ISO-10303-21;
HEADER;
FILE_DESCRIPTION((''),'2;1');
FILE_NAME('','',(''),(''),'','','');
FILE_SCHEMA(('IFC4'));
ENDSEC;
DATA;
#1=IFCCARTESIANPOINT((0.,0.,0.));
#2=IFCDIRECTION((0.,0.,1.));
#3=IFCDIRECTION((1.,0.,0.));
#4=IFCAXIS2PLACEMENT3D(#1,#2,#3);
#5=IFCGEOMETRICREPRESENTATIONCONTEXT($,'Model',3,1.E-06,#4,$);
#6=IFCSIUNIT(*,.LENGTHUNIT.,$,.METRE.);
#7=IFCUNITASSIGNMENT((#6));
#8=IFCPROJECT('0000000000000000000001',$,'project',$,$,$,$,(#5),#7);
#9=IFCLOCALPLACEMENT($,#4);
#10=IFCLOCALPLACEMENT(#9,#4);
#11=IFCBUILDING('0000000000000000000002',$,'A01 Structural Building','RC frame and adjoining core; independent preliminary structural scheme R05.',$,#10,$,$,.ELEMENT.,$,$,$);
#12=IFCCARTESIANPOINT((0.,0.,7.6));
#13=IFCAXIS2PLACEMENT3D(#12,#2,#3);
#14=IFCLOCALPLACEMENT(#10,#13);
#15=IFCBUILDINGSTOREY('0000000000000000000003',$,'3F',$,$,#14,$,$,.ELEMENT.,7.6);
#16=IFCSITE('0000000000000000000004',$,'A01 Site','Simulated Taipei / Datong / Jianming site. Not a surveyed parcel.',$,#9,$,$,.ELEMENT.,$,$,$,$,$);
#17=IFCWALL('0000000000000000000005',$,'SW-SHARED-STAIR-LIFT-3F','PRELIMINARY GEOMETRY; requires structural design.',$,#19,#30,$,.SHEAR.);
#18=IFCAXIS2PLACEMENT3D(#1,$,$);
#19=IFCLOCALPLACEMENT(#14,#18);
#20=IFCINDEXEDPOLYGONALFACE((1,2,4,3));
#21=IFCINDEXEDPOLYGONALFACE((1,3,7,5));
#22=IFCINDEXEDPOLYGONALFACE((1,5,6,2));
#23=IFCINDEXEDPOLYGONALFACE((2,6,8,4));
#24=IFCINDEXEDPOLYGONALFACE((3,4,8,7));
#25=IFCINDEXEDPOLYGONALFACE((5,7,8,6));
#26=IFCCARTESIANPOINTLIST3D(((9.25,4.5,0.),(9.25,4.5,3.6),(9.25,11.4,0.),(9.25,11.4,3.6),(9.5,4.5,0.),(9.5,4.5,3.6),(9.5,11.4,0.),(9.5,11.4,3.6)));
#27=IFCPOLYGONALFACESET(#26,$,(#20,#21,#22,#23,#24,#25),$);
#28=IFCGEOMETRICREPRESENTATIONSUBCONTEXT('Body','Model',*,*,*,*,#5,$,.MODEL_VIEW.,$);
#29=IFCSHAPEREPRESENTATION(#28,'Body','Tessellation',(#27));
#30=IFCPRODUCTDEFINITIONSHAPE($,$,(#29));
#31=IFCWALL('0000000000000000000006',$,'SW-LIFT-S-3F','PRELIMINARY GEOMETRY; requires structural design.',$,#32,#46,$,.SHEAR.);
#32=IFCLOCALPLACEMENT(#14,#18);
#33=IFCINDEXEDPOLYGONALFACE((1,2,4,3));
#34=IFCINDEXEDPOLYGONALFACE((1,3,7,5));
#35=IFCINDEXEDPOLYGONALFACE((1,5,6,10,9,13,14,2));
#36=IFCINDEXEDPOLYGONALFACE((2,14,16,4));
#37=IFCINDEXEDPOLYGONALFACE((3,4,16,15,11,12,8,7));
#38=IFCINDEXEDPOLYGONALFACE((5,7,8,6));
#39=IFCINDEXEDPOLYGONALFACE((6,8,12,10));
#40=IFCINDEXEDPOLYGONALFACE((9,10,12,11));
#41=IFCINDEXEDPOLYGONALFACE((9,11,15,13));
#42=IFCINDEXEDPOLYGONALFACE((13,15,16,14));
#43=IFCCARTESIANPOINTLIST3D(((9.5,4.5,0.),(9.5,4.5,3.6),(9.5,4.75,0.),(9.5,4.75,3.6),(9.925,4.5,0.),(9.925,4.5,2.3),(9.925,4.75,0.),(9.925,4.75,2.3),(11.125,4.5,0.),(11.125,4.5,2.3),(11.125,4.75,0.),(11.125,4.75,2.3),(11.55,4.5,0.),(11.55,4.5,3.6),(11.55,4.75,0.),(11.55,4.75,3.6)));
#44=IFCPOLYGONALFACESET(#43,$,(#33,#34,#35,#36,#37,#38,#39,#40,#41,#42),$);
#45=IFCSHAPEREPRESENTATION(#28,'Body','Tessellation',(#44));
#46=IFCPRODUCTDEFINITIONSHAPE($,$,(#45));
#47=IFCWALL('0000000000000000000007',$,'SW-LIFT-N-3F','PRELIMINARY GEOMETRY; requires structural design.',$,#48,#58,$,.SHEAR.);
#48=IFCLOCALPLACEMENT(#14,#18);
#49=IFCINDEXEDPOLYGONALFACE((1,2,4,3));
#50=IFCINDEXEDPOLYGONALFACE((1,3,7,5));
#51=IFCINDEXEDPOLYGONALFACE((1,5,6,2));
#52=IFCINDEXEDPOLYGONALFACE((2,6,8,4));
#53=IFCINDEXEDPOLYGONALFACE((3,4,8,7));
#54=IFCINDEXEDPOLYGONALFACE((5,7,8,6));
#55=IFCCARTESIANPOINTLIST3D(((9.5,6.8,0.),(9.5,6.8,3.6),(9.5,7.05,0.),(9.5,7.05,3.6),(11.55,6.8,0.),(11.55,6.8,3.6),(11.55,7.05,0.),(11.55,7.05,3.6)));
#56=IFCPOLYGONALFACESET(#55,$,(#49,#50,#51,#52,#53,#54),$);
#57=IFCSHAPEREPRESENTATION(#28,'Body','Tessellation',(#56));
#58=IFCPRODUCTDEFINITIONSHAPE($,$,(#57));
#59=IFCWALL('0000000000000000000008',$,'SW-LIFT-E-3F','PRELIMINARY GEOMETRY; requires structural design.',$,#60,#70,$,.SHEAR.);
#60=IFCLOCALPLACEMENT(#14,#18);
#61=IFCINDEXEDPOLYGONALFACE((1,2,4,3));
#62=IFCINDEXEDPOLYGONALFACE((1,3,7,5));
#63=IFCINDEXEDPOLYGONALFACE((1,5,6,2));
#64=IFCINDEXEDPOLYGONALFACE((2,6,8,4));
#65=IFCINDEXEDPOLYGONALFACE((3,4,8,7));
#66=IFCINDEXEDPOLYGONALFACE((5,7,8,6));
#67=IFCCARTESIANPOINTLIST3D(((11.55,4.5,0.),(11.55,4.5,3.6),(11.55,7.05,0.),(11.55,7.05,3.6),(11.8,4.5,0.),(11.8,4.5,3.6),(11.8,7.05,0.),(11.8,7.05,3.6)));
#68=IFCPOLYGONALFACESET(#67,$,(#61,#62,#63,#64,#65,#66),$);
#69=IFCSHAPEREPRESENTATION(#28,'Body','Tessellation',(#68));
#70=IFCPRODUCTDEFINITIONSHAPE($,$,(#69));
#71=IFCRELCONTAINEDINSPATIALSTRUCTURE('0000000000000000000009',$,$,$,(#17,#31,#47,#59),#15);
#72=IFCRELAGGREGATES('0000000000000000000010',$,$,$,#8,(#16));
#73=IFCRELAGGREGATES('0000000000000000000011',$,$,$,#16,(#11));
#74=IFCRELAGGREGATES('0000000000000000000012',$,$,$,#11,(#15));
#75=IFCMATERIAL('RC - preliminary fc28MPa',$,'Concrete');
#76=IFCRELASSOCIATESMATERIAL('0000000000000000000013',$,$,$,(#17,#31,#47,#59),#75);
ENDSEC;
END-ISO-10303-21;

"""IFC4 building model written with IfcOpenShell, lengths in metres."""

from ifc_helpers import new_model, si_unit, frame, origin_with_axes, place, context, subcontext, project, spatial, rectangle, extrude, material, element, save


model = new_model("IFC4")

# Units and contexts
model_context = context("Model", 3, precision=1e-06, world=origin_with_axes())
body_context = subcontext(model_context, "Body", "Model", "MODEL_VIEW")
ifc_project = project(units=[si_unit("LENGTHUNIT", "METRE")], contexts=[model_context])

# Site, building, storey
site_placement = place(None, origin_with_axes())
site = spatial("IfcSite", under=ifc_project, at=site_placement, Name="A01 Site", Description="Simulated Taipei / Datong / Jianming site. Not a surveyed parcel.", CompositionType="ELEMENT")
building_placement = place(site_placement, origin_with_axes())
building = spatial("IfcBuilding", under=site, at=building_placement, Name="A01 Structural Building", Description="RC frame and adjoining core; independent preliminary structural scheme R05.", CompositionType="ELEMENT")
storey_placement = place(building_placement, frame((0.0, 0.0, 7.6), z_axis=(0.0, 0.0, 1.0), x_axis=(1.0, 0.0, 0.0)))
storey = spatial("IfcBuildingStorey", under=building, at=storey_placement, Name="3F", CompositionType="ELEMENT", Elevation=7.6)

# Shared definitions
ifc_material = material(Name="RC - preliminary fc28MPa", Category="Concrete")

# Wall
wall_1_placement = place(storey_placement, frame((9.375, 7.95, 0.0), z_axis=(0.0, 0.0, 1.0), x_axis=(1.0, 0.0, 0.0)))
element("IfcWall", 1, at=wall_1_placement, inside=storey, material=ifc_material, Name="SW-SHARED-STAIR-LIFT-3F", Description="PRELIMINARY GEOMETRY; requires structural design.", PredefinedType="SHEAR", context=body_context, shape_type="SweptSolid", body=[
    extrude(rectangle(XDim=0.25, YDim=6.9), origin_with_axes(), (0.0, 0.0, 1.0), 3.6),
])

# Wall, opening
wall_2_placement = place(storey_placement, frame((10.525, 4.625, 0.0), z_axis=(0.0, 0.0, 1.0), x_axis=(1.0, 0.0, 0.0)))
wall_2 = element("IfcWall", 2, at=wall_2_placement, inside=storey, material=ifc_material, Name="SW-LIFT-S-3F", Description="PRELIMINARY GEOMETRY; requires structural design.", PredefinedType="SHEAR", context=body_context, shape_type="SweptSolid", body=[
    extrude(rectangle(XDim=2.05, YDim=0.25), origin_with_axes(), (0.0, 0.0, 1.0), 3.6),
])
opening_1_placement = place(storey_placement, frame((10.525, 4.625, 0.0), z_axis=(0.0, 0.0, 1.0), x_axis=(1.0, 0.0, 0.0)))
element("IfcOpeningElement", 3, at=opening_1_placement, cuts=wall_2, PredefinedType="OPENING", context=body_context, shape_type="SweptSolid", body=[
    extrude(rectangle(XDim=1.2, YDim=0.45), origin_with_axes(), (0.0, 0.0, 1.0), 2.3),
])

# Walls
wall_3_placement = place(storey_placement, frame((10.525, 6.925, 0.0), z_axis=(0.0, 0.0, 1.0), x_axis=(1.0, 0.0, 0.0)))
element("IfcWall", 4, at=wall_3_placement, inside=storey, material=ifc_material, Name="SW-LIFT-N-3F", Description="PRELIMINARY GEOMETRY; requires structural design.", PredefinedType="SHEAR", context=body_context, shape_type="SweptSolid", body=[
    extrude(rectangle(XDim=2.05, YDim=0.25), origin_with_axes(), (0.0, 0.0, 1.0), 3.6),
])
wall_4_placement = place(storey_placement, frame((11.675, 5.775, 0.0), z_axis=(0.0, 0.0, 1.0), x_axis=(1.0, 0.0, 0.0)))
element("IfcWall", 5, at=wall_4_placement, inside=storey, material=ifc_material, Name="SW-LIFT-E-3F", Description="PRELIMINARY GEOMETRY; requires structural design.", PredefinedType="SHEAR", context=body_context, shape_type="SweptSolid", body=[
    extrude(rectangle(XDim=0.25, YDim=2.55), origin_with_axes(), (0.0, 0.0, 1.0), 3.6),
])

save(model, "model.ifc")
